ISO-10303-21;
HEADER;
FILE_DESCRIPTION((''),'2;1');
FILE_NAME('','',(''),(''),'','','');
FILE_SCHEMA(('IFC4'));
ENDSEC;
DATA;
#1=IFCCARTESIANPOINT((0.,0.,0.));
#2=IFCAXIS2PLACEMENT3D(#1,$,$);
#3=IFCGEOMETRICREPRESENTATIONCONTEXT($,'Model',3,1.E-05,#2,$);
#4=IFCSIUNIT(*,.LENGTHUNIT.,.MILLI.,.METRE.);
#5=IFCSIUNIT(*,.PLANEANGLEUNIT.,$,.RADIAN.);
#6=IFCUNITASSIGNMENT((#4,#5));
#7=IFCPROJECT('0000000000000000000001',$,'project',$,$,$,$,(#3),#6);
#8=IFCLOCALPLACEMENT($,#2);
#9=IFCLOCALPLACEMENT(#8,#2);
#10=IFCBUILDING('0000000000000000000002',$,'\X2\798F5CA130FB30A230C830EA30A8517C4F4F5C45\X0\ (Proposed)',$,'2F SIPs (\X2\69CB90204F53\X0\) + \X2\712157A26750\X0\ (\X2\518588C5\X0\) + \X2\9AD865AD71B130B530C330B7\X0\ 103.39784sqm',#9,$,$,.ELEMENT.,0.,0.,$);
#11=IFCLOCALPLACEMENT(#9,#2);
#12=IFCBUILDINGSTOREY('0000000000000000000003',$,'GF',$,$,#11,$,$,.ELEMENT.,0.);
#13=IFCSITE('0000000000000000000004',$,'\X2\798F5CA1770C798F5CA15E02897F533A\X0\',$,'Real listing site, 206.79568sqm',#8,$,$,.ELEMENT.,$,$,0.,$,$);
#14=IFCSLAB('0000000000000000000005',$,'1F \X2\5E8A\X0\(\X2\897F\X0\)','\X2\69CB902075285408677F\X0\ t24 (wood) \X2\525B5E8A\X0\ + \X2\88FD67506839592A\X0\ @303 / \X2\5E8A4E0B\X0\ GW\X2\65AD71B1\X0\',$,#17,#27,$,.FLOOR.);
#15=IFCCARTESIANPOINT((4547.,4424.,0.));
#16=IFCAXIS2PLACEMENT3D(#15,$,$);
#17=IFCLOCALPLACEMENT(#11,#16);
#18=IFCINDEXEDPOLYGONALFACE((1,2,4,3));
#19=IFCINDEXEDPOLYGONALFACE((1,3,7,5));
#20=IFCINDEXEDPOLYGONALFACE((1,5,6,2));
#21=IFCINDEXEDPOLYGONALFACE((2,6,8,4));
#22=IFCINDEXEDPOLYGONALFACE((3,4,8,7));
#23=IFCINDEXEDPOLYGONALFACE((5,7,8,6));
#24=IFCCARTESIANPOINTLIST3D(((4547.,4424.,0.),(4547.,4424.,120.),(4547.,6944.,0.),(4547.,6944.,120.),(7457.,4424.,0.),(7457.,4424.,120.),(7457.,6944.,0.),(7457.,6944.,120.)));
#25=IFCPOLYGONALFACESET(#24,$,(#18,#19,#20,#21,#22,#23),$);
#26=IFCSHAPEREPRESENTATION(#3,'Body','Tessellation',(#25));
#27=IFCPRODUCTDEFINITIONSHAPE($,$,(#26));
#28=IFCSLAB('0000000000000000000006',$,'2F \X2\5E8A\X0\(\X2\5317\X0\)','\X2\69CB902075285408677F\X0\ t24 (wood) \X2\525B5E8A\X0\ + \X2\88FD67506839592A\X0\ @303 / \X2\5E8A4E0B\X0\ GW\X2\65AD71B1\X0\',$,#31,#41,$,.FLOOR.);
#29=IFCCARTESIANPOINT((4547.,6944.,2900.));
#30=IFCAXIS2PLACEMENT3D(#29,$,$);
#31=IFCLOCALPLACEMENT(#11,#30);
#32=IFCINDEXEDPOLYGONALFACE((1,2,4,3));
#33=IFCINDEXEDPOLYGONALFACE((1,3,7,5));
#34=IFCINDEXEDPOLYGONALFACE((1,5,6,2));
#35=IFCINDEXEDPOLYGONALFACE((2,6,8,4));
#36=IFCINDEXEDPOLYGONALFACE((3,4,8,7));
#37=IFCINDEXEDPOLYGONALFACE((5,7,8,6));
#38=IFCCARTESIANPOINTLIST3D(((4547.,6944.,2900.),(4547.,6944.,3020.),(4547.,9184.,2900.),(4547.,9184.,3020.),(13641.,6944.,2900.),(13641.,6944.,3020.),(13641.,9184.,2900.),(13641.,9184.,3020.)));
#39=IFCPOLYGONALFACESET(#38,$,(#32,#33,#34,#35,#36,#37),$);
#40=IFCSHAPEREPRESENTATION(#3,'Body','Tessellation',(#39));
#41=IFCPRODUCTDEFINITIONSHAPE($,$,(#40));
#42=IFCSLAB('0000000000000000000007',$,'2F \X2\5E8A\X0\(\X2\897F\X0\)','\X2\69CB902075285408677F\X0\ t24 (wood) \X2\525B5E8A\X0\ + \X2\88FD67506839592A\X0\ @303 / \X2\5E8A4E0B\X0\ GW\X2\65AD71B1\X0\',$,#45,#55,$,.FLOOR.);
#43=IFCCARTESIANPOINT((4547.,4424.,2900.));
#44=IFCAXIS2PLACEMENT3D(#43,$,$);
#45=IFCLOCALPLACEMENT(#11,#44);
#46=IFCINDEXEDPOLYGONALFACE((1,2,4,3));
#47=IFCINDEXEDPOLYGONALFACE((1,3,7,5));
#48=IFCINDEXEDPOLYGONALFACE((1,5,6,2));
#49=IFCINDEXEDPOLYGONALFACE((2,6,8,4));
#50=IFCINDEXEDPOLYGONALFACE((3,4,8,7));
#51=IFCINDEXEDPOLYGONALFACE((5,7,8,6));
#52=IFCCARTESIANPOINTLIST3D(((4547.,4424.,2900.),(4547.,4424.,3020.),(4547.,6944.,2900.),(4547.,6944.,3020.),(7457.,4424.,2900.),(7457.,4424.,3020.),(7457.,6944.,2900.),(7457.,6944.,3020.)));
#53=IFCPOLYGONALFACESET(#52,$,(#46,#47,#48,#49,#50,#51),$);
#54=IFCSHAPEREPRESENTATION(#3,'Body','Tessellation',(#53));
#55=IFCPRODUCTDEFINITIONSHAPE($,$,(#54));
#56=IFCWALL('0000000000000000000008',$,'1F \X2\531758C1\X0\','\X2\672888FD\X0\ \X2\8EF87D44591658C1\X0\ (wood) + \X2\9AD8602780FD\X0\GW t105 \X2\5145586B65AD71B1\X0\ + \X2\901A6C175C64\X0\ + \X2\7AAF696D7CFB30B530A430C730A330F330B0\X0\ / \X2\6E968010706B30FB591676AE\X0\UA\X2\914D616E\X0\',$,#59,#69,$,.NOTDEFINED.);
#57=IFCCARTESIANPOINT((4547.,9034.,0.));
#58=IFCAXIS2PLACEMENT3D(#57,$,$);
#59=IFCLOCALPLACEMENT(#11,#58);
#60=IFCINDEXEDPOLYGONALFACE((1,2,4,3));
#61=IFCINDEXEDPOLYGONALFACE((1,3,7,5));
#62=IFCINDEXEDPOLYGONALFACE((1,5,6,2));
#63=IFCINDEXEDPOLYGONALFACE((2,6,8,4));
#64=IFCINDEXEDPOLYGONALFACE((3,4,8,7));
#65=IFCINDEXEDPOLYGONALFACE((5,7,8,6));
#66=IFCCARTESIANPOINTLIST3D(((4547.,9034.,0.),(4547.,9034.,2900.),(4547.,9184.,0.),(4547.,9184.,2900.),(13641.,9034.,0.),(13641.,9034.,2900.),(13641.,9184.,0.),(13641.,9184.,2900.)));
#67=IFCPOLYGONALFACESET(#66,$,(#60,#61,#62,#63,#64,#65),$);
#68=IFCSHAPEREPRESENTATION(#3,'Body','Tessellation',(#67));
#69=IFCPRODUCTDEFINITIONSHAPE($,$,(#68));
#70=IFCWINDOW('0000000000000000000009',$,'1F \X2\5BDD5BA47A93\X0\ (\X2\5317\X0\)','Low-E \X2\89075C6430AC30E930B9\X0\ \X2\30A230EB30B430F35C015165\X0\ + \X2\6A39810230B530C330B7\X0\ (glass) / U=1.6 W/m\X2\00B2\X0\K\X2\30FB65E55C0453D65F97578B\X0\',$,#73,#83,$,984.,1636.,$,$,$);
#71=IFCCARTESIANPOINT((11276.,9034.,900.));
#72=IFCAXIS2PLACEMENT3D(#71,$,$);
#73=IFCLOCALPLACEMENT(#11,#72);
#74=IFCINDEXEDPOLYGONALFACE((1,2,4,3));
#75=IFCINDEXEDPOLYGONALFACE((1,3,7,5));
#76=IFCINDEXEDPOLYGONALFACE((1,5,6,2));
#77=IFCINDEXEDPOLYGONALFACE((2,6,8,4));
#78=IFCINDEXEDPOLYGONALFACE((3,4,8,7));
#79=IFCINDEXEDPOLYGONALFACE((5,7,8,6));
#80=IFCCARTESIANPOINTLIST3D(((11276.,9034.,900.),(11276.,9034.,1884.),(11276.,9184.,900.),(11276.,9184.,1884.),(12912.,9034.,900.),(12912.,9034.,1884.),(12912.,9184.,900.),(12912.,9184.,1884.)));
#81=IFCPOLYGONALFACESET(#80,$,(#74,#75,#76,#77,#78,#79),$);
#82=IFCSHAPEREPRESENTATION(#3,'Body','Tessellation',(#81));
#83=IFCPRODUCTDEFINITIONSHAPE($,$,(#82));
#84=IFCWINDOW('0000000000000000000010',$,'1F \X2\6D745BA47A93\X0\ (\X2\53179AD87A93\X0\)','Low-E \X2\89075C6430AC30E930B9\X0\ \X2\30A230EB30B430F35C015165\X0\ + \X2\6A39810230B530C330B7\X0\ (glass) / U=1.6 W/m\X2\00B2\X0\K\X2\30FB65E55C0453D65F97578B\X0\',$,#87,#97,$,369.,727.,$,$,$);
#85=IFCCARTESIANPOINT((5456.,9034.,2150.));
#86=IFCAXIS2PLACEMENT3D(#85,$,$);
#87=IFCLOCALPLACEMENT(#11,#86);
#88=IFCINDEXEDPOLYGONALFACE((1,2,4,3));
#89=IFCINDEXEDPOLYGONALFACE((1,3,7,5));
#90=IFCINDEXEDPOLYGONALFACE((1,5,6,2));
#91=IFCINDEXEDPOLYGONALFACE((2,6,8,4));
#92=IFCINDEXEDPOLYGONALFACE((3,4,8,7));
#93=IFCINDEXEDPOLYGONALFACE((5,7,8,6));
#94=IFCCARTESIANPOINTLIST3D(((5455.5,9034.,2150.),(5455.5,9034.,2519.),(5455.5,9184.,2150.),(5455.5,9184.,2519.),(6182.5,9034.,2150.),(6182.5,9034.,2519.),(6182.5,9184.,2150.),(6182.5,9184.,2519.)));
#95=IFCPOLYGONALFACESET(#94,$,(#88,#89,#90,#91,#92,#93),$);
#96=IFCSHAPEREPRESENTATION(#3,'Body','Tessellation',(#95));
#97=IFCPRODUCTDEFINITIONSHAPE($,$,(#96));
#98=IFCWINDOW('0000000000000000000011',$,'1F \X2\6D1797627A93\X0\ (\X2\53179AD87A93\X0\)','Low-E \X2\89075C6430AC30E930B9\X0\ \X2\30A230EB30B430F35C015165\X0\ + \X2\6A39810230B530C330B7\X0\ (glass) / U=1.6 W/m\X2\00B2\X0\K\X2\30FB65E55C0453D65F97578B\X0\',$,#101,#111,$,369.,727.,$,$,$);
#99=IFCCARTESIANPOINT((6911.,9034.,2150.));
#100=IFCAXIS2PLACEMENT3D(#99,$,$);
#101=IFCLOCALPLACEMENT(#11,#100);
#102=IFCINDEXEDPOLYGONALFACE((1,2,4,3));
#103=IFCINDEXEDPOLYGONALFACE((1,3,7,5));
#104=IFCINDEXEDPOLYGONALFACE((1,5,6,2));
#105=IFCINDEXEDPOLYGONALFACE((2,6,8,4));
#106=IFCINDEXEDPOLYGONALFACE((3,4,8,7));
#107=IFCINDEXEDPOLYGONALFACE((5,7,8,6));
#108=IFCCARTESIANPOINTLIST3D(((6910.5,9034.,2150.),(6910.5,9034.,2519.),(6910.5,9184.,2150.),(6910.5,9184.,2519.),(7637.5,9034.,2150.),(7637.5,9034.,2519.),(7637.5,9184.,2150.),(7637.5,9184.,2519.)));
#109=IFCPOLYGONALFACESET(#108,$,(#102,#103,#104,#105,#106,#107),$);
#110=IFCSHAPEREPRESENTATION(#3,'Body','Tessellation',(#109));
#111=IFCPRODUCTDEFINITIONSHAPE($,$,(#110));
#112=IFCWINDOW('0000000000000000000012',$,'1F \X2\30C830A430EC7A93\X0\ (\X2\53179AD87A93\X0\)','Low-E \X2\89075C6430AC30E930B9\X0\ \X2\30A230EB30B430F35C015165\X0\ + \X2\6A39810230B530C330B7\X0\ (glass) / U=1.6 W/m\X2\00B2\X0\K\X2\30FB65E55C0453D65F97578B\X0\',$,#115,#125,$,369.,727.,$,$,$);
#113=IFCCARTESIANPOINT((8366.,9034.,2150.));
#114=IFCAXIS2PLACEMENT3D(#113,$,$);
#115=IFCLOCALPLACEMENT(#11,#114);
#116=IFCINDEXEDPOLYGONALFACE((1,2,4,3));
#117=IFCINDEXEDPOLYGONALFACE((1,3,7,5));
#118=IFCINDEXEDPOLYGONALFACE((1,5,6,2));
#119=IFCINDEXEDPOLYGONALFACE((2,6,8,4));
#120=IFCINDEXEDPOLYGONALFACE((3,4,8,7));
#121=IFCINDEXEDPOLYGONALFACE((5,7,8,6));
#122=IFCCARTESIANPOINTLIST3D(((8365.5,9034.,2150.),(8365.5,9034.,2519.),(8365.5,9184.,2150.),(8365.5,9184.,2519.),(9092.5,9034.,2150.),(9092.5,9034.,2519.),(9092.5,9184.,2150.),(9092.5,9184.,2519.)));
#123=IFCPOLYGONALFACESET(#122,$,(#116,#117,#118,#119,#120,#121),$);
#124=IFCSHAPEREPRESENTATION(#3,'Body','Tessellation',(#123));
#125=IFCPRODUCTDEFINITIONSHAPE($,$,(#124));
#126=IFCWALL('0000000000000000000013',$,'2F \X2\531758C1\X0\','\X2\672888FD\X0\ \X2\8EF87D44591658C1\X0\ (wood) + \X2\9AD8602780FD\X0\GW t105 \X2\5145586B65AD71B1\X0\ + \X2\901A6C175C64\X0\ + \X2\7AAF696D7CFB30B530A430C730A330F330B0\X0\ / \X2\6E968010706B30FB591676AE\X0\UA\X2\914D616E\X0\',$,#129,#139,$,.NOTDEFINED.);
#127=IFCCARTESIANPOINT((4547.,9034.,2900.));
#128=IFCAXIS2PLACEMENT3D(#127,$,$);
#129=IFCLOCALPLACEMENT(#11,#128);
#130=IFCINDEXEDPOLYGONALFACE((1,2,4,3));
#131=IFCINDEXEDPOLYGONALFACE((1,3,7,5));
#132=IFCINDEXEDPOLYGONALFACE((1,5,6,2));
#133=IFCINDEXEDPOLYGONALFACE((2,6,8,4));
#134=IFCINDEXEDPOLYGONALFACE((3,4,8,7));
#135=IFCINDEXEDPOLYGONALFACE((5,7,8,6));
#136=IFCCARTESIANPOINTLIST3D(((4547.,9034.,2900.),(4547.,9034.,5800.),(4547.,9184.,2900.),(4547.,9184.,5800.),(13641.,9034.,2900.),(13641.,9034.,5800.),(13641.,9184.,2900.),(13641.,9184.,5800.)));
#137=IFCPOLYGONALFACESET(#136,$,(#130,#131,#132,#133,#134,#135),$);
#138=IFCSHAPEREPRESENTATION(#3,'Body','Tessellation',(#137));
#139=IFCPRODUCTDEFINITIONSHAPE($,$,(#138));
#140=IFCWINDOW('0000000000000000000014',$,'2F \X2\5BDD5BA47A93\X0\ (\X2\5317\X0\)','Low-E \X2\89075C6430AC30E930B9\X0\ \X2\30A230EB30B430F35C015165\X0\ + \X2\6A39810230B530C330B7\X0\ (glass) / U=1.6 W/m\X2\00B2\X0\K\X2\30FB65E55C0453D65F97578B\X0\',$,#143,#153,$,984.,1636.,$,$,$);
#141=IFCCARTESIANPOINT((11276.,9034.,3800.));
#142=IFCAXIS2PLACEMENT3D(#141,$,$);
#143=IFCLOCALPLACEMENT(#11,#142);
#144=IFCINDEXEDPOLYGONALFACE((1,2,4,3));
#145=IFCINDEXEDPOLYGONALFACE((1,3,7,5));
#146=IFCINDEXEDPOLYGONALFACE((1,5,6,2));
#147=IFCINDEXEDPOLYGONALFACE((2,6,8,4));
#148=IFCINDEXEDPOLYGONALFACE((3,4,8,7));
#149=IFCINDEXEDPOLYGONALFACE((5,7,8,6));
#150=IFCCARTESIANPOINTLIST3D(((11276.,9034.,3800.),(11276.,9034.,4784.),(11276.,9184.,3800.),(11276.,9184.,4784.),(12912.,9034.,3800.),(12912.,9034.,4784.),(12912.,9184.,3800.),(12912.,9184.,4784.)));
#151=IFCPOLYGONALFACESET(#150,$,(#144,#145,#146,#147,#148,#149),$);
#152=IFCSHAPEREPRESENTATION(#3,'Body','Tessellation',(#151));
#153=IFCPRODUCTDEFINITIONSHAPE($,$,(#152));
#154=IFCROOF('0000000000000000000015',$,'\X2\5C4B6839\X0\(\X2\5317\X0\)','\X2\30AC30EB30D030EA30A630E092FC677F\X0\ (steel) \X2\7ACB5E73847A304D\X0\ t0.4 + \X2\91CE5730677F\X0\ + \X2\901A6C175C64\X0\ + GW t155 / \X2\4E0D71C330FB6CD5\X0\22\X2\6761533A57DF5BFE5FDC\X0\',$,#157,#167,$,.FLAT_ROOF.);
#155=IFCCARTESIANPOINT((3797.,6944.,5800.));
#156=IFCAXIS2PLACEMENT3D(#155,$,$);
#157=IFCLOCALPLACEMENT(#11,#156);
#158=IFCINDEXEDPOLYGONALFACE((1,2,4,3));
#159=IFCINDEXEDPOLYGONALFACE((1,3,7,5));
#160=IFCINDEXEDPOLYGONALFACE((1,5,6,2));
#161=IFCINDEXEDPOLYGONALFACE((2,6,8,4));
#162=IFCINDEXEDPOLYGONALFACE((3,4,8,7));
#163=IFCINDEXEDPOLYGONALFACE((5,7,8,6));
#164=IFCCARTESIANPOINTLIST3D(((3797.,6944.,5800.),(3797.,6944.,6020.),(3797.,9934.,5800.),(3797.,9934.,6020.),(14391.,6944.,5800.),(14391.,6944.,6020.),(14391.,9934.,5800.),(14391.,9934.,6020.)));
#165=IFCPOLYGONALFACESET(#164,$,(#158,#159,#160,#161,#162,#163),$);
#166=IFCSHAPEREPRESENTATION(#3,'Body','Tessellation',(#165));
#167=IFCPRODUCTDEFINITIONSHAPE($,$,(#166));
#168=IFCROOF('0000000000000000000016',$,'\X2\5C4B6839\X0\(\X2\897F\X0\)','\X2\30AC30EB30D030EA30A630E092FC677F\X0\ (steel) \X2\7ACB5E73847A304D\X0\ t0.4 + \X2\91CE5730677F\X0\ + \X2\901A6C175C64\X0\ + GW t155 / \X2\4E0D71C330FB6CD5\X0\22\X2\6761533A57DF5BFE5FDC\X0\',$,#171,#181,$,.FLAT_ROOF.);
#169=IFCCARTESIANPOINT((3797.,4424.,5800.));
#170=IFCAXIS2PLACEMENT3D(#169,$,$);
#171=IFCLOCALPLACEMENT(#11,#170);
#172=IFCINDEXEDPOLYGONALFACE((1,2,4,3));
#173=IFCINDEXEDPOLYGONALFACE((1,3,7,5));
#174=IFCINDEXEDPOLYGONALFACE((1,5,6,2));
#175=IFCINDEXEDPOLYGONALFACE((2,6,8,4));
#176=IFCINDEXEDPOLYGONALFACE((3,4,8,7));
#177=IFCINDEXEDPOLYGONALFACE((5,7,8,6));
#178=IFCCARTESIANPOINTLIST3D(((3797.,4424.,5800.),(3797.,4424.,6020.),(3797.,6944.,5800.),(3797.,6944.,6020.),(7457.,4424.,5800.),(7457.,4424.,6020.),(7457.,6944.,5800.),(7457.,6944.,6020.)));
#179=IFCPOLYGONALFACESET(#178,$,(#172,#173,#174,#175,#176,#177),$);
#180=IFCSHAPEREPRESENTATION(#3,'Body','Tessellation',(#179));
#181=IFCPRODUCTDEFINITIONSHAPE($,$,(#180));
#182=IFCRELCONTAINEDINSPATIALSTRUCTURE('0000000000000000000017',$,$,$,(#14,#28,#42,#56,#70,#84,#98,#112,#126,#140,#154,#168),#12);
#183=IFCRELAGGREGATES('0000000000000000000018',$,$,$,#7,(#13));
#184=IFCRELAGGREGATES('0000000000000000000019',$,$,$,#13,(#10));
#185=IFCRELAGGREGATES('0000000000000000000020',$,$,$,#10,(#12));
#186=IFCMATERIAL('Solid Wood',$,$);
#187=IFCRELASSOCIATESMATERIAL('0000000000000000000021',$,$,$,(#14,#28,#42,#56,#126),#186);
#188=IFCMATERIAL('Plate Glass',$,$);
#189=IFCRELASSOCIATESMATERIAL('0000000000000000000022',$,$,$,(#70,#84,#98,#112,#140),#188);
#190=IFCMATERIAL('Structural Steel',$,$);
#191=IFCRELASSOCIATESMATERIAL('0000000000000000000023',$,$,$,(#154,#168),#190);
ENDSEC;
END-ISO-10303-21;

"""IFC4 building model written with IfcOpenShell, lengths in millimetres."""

from ifc_helpers import new_model, si_unit, frame, frame_2d, origin, place, context, project, spatial, rectangle, extrude, material, element, fill, save


model = new_model("IFC4")

# Units and contexts
model_context = context("Model", 3, precision=1e-05, world=origin())
ifc_project = project(units=[si_unit("LENGTHUNIT", "METRE", prefix="MILLI"), si_unit("PLANEANGLEUNIT", "RADIAN")], contexts=[model_context])

# Site, building, storey
site_placement = place(None, origin())
site = spatial("IfcSite", under=ifc_project, at=site_placement, Name="福岡県福岡市西区", ObjectType="Real listing site, 206.79568sqm", CompositionType="ELEMENT", RefElevation=0.0)
building_placement = place(site_placement, origin())
building = spatial("IfcBuilding", under=site, at=building_placement, Name="福岡・アトリエ兼住居 (Proposed)", ObjectType="2F SIPs (構造体) + 無垢材 (内装) + 高断熱サッシ 103.39784sqm", CompositionType="ELEMENT", ElevationOfRefHeight=0.0, ElevationOfTerrain=0.0)
storey_placement = place(building_placement, origin())
storey = spatial("IfcBuildingStorey", under=building, at=storey_placement, Name="GF", CompositionType="ELEMENT", Elevation=0.0)

# Slabs
ifc_material_1 = material(Name="Solid Wood")
slab_1_placement = place(storey_placement, frame((4547.0, 4424.0, 0.0)))
element("IfcSlab", 1, at=slab_1_placement, inside=storey, material=ifc_material_1, Name="1F 床(西)", Description="構造用合板 t24 (wood) 剛床 + 製材根太 @303 / 床下 GW断熱", PredefinedType="FLOOR", context=model_context, shape_type="SweptSolid", body=[
    extrude(rectangle(XDim=2910.0, YDim=2520.0, at=frame_2d((1455.0, 1260.0))), frame((4547.0, 4424.0, 0.0)), (0.0, 0.0, 1.0), 120.0),
])
slab_2_placement = place(storey_placement, frame((4547.0, 6944.0, 2900.0)))
element("IfcSlab", 2, at=slab_2_placement, inside=storey, material=ifc_material_1, Name="2F 床(北)", Description="構造用合板 t24 (wood) 剛床 + 製材根太 @303 / 床下 GW断熱", PredefinedType="FLOOR", context=model_context, shape_type="SweptSolid", body=[
    extrude(rectangle(XDim=9094.0, YDim=2240.0, at=frame_2d((4547.0, 1120.0))), frame((4547.0, 6944.0, 2900.0)), (0.0, 0.0, 1.0), 120.0),
])
slab_3_placement = place(storey_placement, frame((4547.0, 4424.0, 2900.0)))
element("IfcSlab", 3, at=slab_3_placement, inside=storey, material=ifc_material_1, Name="2F 床(西)", Description="構造用合板 t24 (wood) 剛床 + 製材根太 @303 / 床下 GW断熱", PredefinedType="FLOOR", context=model_context, shape_type="SweptSolid", body=[
    extrude(rectangle(XDim=2910.0, YDim=2520.0, at=frame_2d((1455.0, 1260.0))), frame((4547.0, 4424.0, 2900.0)), (0.0, 0.0, 1.0), 120.0),
])

# Wall, openings, windows
wall_1_placement = place(storey_placement, frame((4547.0, 9034.0, 0.0)))
wall_1 = element("IfcWall", 4, at=wall_1_placement, inside=storey, material=ifc_material_1, Name="1F 北壁", Description="木製 軸組外壁 (wood) + 高性能GW t105 充填断熱 + 通気層 + 窯業系サイディング / 準耐火・外皮UA配慮", PredefinedType="NOTDEFINED", context=model_context, shape_type="SweptSolid", body=[
    extrude(rectangle(XDim=9094.0, YDim=150.0, at=frame_2d((4547.0, 75.0))), frame((4547.0, 9034.0, 0.0)), (0.0, 0.0, 1.0), 2900.0),
])
opening_1_placement = place(storey_placement, frame((11276.0, 9034.0, 900.0)))
opening_1 = element("IfcOpeningElement", 5, at=opening_1_placement, cuts=wall_1, PredefinedType="NOTDEFINED", context=model_context, shape_type="SweptSolid", body=[
    extrude(rectangle(XDim=1636.0, YDim=150.0, at=frame_2d((818.0, 75.0))), frame((11276.0, 9034.0, 900.0)), (0.0, 0.0, 1.0), 984.0),
])
opening_2_placement = place(storey_placement, frame((5456.0, 9034.0, 2150.0)))
opening_2 = element("IfcOpeningElement", 6, at=opening_2_placement, cuts=wall_1, PredefinedType="NOTDEFINED", context=model_context, shape_type="SweptSolid", body=[
    extrude(rectangle(XDim=727.0, YDim=150.0, at=frame_2d((363.0, 75.0))), frame((5456.0, 9034.0, 2150.0)), (0.0, 0.0, 1.0), 369.0),
])
opening_3_placement = place(storey_placement, frame((6911.0, 9034.0, 2150.0)))
opening_3 = element("IfcOpeningElement", 7, at=opening_3_placement, cuts=wall_1, PredefinedType="NOTDEFINED", context=model_context, shape_type="SweptSolid", body=[
    extrude(rectangle(XDim=727.0, YDim=150.0, at=frame_2d((363.0, 75.0))), frame((6911.0, 9034.0, 2150.0)), (0.0, 0.0, 1.0), 369.0),
])
opening_4_placement = place(storey_placement, frame((8366.0, 9034.0, 2150.0)))
opening_4 = element("IfcOpeningElement", 8, at=opening_4_placement, cuts=wall_1, PredefinedType="NOTDEFINED", context=model_context, shape_type="SweptSolid", body=[
    extrude(rectangle(XDim=727.0, YDim=150.0, at=frame_2d((363.0, 75.0))), frame((8366.0, 9034.0, 2150.0)), (0.0, 0.0, 1.0), 369.0),
])
ifc_material_2 = material(Name="Plate Glass")
window_1_placement = place(storey_placement, frame((11276.0, 9034.0, 900.0)))
window_1 = element("IfcWindow", 9, at=window_1_placement, inside=storey, material=ifc_material_2, Name="1F 寝室窓 (北)", Description="Low-E 複層ガラス アルゴン封入 + 樹脂サッシ (glass) / U=1.6 W/m²K・日射取得型", OverallHeight=984.0, OverallWidth=1636.0, context=model_context, shape_type="SweptSolid", body=[
    extrude(rectangle(XDim=1636.0, YDim=150.0, at=frame_2d((818.0, 75.0))), frame((11276.0, 9034.0, 900.0)), (0.0, 0.0, 1.0), 984.0),
])
fill(opening_1, window_1)
window_2_placement = place(storey_placement, frame((5456.0, 9034.0, 2150.0)))
window_2 = element("IfcWindow", 10, at=window_2_placement, inside=storey, material=ifc_material_2, Name="1F 浴室窓 (北高窓)", Description="Low-E 複層ガラス アルゴン封入 + 樹脂サッシ (glass) / U=1.6 W/m²K・日射取得型", OverallHeight=369.0, OverallWidth=727.0, context=model_context, shape_type="SweptSolid", body=[
    extrude(rectangle(XDim=727.0, YDim=150.0, at=frame_2d((363.0, 75.0))), frame((5456.0, 9034.0, 2150.0)), (0.0, 0.0, 1.0), 369.0),
])
fill(opening_2, window_2)
window_3_placement = place(storey_placement, frame((6911.0, 9034.0, 2150.0)))
window_3 = element("IfcWindow", 11, at=window_3_placement, inside=storey, material=ifc_material_2, Name="1F 洗面窓 (北高窓)", Description="Low-E 複層ガラス アルゴン封入 + 樹脂サッシ (glass) / U=1.6 W/m²K・日射取得型", OverallHeight=369.0, OverallWidth=727.0, context=model_context, shape_type="SweptSolid", body=[
    extrude(rectangle(XDim=727.0, YDim=150.0, at=frame_2d((363.0, 75.0))), frame((6911.0, 9034.0, 2150.0)), (0.0, 0.0, 1.0), 369.0),
])
fill(opening_3, window_3)
window_4_placement = place(storey_placement, frame((8366.0, 9034.0, 2150.0)))
window_4 = element("IfcWindow", 12, at=window_4_placement, inside=storey, material=ifc_material_2, Name="1F トイレ窓 (北高窓)", Description="Low-E 複層ガラス アルゴン封入 + 樹脂サッシ (glass) / U=1.6 W/m²K・日射取得型", OverallHeight=369.0, OverallWidth=727.0, context=model_context, shape_type="SweptSolid", body=[
    extrude(rectangle(XDim=727.0, YDim=150.0, at=frame_2d((363.0, 75.0))), frame((8366.0, 9034.0, 2150.0)), (0.0, 0.0, 1.0), 369.0),
])
fill(opening_4, window_4)

# Wall, opening, window
wall_2_placement = place(storey_placement, frame((4547.0, 9034.0, 2900.0)))
wall_2 = element("IfcWall", 13, at=wall_2_placement, inside=storey, material=ifc_material_1, Name="2F 北壁", Description="木製 軸組外壁 (wood) + 高性能GW t105 充填断熱 + 通気層 + 窯業系サイディング / 準耐火・外皮UA配慮", PredefinedType="NOTDEFINED", context=model_context, shape_type="SweptSolid", body=[
    extrude(rectangle(XDim=9094.0, YDim=150.0, at=frame_2d((4547.0, 75.0))), frame((4547.0, 9034.0, 2900.0)), (0.0, 0.0, 1.0), 2900.0),
])
opening_5_placement = place(storey_placement, frame((11276.0, 9034.0, 3800.0)))
opening_5 = element("IfcOpeningElement", 14, at=opening_5_placement, cuts=wall_2, PredefinedType="NOTDEFINED", context=model_context, shape_type="SweptSolid", body=[
    extrude(rectangle(XDim=1636.0, YDim=150.0, at=frame_2d((818.0, 75.0))), frame((11276.0, 9034.0, 3800.0)), (0.0, 0.0, 1.0), 984.0),
])
window_5_placement = place(storey_placement, frame((11276.0, 9034.0, 3800.0)))
window_5 = element("IfcWindow", 15, at=window_5_placement, inside=storey, material=ifc_material_2, Name="2F 寝室窓 (北)", Description="Low-E 複層ガラス アルゴン封入 + 樹脂サッシ (glass) / U=1.6 W/m²K・日射取得型", OverallHeight=984.0, OverallWidth=1636.0, context=model_context, shape_type="SweptSolid", body=[
    extrude(rectangle(XDim=1636.0, YDim=150.0, at=frame_2d((818.0, 75.0))), frame((11276.0, 9034.0, 3800.0)), (0.0, 0.0, 1.0), 984.0),
])
fill(opening_5, window_5)

# Roofs
ifc_material_3 = material(Name="Structural Steel")
for number, where, name in (
    (16, (3797.0, 6944.0, 5800.0), "屋根(北)"),
):
    element("IfcRoof", number, at=place(storey_placement, frame(where)), inside=storey, material=ifc_material_3, Name=name, Description="ガルバリウム鋼板 (steel) 立平葺き t0.4 + 野地板 + 通気層 + GW t155 / 不燃・法22条区域対応", PredefinedType="FLAT_ROOF", context=model_context, shape_type="SweptSolid", body=[
        extrude(rectangle(XDim=10594.0, YDim=2990.0, at=frame_2d((5297.0, 1495.0))), frame((3797.0, 6944.0, 5800.0)), (0.0, 0.0, 1.0), 220.0),
    ])
roof_placement = place(storey_placement, frame((3797.0, 4424.0, 5800.0)))
element("IfcRoof", 17, at=roof_placement, inside=storey, material=ifc_material_3, Name="屋根(西)", Description="ガルバリウム鋼板 (steel) 立平葺き t0.4 + 野地板 + 通気層 + GW t155 / 不燃・法22条区域対応", PredefinedType="FLAT_ROOF", context=model_context, shape_type="SweptSolid", body=[
    extrude(rectangle(XDim=3660.0, YDim=2520.0, at=frame_2d((1830.0, 1260.0))), frame((3797.0, 4424.0, 5800.0)), (0.0, 0.0, 1.0), 220.0),
])

save(model, "model.ifc")
